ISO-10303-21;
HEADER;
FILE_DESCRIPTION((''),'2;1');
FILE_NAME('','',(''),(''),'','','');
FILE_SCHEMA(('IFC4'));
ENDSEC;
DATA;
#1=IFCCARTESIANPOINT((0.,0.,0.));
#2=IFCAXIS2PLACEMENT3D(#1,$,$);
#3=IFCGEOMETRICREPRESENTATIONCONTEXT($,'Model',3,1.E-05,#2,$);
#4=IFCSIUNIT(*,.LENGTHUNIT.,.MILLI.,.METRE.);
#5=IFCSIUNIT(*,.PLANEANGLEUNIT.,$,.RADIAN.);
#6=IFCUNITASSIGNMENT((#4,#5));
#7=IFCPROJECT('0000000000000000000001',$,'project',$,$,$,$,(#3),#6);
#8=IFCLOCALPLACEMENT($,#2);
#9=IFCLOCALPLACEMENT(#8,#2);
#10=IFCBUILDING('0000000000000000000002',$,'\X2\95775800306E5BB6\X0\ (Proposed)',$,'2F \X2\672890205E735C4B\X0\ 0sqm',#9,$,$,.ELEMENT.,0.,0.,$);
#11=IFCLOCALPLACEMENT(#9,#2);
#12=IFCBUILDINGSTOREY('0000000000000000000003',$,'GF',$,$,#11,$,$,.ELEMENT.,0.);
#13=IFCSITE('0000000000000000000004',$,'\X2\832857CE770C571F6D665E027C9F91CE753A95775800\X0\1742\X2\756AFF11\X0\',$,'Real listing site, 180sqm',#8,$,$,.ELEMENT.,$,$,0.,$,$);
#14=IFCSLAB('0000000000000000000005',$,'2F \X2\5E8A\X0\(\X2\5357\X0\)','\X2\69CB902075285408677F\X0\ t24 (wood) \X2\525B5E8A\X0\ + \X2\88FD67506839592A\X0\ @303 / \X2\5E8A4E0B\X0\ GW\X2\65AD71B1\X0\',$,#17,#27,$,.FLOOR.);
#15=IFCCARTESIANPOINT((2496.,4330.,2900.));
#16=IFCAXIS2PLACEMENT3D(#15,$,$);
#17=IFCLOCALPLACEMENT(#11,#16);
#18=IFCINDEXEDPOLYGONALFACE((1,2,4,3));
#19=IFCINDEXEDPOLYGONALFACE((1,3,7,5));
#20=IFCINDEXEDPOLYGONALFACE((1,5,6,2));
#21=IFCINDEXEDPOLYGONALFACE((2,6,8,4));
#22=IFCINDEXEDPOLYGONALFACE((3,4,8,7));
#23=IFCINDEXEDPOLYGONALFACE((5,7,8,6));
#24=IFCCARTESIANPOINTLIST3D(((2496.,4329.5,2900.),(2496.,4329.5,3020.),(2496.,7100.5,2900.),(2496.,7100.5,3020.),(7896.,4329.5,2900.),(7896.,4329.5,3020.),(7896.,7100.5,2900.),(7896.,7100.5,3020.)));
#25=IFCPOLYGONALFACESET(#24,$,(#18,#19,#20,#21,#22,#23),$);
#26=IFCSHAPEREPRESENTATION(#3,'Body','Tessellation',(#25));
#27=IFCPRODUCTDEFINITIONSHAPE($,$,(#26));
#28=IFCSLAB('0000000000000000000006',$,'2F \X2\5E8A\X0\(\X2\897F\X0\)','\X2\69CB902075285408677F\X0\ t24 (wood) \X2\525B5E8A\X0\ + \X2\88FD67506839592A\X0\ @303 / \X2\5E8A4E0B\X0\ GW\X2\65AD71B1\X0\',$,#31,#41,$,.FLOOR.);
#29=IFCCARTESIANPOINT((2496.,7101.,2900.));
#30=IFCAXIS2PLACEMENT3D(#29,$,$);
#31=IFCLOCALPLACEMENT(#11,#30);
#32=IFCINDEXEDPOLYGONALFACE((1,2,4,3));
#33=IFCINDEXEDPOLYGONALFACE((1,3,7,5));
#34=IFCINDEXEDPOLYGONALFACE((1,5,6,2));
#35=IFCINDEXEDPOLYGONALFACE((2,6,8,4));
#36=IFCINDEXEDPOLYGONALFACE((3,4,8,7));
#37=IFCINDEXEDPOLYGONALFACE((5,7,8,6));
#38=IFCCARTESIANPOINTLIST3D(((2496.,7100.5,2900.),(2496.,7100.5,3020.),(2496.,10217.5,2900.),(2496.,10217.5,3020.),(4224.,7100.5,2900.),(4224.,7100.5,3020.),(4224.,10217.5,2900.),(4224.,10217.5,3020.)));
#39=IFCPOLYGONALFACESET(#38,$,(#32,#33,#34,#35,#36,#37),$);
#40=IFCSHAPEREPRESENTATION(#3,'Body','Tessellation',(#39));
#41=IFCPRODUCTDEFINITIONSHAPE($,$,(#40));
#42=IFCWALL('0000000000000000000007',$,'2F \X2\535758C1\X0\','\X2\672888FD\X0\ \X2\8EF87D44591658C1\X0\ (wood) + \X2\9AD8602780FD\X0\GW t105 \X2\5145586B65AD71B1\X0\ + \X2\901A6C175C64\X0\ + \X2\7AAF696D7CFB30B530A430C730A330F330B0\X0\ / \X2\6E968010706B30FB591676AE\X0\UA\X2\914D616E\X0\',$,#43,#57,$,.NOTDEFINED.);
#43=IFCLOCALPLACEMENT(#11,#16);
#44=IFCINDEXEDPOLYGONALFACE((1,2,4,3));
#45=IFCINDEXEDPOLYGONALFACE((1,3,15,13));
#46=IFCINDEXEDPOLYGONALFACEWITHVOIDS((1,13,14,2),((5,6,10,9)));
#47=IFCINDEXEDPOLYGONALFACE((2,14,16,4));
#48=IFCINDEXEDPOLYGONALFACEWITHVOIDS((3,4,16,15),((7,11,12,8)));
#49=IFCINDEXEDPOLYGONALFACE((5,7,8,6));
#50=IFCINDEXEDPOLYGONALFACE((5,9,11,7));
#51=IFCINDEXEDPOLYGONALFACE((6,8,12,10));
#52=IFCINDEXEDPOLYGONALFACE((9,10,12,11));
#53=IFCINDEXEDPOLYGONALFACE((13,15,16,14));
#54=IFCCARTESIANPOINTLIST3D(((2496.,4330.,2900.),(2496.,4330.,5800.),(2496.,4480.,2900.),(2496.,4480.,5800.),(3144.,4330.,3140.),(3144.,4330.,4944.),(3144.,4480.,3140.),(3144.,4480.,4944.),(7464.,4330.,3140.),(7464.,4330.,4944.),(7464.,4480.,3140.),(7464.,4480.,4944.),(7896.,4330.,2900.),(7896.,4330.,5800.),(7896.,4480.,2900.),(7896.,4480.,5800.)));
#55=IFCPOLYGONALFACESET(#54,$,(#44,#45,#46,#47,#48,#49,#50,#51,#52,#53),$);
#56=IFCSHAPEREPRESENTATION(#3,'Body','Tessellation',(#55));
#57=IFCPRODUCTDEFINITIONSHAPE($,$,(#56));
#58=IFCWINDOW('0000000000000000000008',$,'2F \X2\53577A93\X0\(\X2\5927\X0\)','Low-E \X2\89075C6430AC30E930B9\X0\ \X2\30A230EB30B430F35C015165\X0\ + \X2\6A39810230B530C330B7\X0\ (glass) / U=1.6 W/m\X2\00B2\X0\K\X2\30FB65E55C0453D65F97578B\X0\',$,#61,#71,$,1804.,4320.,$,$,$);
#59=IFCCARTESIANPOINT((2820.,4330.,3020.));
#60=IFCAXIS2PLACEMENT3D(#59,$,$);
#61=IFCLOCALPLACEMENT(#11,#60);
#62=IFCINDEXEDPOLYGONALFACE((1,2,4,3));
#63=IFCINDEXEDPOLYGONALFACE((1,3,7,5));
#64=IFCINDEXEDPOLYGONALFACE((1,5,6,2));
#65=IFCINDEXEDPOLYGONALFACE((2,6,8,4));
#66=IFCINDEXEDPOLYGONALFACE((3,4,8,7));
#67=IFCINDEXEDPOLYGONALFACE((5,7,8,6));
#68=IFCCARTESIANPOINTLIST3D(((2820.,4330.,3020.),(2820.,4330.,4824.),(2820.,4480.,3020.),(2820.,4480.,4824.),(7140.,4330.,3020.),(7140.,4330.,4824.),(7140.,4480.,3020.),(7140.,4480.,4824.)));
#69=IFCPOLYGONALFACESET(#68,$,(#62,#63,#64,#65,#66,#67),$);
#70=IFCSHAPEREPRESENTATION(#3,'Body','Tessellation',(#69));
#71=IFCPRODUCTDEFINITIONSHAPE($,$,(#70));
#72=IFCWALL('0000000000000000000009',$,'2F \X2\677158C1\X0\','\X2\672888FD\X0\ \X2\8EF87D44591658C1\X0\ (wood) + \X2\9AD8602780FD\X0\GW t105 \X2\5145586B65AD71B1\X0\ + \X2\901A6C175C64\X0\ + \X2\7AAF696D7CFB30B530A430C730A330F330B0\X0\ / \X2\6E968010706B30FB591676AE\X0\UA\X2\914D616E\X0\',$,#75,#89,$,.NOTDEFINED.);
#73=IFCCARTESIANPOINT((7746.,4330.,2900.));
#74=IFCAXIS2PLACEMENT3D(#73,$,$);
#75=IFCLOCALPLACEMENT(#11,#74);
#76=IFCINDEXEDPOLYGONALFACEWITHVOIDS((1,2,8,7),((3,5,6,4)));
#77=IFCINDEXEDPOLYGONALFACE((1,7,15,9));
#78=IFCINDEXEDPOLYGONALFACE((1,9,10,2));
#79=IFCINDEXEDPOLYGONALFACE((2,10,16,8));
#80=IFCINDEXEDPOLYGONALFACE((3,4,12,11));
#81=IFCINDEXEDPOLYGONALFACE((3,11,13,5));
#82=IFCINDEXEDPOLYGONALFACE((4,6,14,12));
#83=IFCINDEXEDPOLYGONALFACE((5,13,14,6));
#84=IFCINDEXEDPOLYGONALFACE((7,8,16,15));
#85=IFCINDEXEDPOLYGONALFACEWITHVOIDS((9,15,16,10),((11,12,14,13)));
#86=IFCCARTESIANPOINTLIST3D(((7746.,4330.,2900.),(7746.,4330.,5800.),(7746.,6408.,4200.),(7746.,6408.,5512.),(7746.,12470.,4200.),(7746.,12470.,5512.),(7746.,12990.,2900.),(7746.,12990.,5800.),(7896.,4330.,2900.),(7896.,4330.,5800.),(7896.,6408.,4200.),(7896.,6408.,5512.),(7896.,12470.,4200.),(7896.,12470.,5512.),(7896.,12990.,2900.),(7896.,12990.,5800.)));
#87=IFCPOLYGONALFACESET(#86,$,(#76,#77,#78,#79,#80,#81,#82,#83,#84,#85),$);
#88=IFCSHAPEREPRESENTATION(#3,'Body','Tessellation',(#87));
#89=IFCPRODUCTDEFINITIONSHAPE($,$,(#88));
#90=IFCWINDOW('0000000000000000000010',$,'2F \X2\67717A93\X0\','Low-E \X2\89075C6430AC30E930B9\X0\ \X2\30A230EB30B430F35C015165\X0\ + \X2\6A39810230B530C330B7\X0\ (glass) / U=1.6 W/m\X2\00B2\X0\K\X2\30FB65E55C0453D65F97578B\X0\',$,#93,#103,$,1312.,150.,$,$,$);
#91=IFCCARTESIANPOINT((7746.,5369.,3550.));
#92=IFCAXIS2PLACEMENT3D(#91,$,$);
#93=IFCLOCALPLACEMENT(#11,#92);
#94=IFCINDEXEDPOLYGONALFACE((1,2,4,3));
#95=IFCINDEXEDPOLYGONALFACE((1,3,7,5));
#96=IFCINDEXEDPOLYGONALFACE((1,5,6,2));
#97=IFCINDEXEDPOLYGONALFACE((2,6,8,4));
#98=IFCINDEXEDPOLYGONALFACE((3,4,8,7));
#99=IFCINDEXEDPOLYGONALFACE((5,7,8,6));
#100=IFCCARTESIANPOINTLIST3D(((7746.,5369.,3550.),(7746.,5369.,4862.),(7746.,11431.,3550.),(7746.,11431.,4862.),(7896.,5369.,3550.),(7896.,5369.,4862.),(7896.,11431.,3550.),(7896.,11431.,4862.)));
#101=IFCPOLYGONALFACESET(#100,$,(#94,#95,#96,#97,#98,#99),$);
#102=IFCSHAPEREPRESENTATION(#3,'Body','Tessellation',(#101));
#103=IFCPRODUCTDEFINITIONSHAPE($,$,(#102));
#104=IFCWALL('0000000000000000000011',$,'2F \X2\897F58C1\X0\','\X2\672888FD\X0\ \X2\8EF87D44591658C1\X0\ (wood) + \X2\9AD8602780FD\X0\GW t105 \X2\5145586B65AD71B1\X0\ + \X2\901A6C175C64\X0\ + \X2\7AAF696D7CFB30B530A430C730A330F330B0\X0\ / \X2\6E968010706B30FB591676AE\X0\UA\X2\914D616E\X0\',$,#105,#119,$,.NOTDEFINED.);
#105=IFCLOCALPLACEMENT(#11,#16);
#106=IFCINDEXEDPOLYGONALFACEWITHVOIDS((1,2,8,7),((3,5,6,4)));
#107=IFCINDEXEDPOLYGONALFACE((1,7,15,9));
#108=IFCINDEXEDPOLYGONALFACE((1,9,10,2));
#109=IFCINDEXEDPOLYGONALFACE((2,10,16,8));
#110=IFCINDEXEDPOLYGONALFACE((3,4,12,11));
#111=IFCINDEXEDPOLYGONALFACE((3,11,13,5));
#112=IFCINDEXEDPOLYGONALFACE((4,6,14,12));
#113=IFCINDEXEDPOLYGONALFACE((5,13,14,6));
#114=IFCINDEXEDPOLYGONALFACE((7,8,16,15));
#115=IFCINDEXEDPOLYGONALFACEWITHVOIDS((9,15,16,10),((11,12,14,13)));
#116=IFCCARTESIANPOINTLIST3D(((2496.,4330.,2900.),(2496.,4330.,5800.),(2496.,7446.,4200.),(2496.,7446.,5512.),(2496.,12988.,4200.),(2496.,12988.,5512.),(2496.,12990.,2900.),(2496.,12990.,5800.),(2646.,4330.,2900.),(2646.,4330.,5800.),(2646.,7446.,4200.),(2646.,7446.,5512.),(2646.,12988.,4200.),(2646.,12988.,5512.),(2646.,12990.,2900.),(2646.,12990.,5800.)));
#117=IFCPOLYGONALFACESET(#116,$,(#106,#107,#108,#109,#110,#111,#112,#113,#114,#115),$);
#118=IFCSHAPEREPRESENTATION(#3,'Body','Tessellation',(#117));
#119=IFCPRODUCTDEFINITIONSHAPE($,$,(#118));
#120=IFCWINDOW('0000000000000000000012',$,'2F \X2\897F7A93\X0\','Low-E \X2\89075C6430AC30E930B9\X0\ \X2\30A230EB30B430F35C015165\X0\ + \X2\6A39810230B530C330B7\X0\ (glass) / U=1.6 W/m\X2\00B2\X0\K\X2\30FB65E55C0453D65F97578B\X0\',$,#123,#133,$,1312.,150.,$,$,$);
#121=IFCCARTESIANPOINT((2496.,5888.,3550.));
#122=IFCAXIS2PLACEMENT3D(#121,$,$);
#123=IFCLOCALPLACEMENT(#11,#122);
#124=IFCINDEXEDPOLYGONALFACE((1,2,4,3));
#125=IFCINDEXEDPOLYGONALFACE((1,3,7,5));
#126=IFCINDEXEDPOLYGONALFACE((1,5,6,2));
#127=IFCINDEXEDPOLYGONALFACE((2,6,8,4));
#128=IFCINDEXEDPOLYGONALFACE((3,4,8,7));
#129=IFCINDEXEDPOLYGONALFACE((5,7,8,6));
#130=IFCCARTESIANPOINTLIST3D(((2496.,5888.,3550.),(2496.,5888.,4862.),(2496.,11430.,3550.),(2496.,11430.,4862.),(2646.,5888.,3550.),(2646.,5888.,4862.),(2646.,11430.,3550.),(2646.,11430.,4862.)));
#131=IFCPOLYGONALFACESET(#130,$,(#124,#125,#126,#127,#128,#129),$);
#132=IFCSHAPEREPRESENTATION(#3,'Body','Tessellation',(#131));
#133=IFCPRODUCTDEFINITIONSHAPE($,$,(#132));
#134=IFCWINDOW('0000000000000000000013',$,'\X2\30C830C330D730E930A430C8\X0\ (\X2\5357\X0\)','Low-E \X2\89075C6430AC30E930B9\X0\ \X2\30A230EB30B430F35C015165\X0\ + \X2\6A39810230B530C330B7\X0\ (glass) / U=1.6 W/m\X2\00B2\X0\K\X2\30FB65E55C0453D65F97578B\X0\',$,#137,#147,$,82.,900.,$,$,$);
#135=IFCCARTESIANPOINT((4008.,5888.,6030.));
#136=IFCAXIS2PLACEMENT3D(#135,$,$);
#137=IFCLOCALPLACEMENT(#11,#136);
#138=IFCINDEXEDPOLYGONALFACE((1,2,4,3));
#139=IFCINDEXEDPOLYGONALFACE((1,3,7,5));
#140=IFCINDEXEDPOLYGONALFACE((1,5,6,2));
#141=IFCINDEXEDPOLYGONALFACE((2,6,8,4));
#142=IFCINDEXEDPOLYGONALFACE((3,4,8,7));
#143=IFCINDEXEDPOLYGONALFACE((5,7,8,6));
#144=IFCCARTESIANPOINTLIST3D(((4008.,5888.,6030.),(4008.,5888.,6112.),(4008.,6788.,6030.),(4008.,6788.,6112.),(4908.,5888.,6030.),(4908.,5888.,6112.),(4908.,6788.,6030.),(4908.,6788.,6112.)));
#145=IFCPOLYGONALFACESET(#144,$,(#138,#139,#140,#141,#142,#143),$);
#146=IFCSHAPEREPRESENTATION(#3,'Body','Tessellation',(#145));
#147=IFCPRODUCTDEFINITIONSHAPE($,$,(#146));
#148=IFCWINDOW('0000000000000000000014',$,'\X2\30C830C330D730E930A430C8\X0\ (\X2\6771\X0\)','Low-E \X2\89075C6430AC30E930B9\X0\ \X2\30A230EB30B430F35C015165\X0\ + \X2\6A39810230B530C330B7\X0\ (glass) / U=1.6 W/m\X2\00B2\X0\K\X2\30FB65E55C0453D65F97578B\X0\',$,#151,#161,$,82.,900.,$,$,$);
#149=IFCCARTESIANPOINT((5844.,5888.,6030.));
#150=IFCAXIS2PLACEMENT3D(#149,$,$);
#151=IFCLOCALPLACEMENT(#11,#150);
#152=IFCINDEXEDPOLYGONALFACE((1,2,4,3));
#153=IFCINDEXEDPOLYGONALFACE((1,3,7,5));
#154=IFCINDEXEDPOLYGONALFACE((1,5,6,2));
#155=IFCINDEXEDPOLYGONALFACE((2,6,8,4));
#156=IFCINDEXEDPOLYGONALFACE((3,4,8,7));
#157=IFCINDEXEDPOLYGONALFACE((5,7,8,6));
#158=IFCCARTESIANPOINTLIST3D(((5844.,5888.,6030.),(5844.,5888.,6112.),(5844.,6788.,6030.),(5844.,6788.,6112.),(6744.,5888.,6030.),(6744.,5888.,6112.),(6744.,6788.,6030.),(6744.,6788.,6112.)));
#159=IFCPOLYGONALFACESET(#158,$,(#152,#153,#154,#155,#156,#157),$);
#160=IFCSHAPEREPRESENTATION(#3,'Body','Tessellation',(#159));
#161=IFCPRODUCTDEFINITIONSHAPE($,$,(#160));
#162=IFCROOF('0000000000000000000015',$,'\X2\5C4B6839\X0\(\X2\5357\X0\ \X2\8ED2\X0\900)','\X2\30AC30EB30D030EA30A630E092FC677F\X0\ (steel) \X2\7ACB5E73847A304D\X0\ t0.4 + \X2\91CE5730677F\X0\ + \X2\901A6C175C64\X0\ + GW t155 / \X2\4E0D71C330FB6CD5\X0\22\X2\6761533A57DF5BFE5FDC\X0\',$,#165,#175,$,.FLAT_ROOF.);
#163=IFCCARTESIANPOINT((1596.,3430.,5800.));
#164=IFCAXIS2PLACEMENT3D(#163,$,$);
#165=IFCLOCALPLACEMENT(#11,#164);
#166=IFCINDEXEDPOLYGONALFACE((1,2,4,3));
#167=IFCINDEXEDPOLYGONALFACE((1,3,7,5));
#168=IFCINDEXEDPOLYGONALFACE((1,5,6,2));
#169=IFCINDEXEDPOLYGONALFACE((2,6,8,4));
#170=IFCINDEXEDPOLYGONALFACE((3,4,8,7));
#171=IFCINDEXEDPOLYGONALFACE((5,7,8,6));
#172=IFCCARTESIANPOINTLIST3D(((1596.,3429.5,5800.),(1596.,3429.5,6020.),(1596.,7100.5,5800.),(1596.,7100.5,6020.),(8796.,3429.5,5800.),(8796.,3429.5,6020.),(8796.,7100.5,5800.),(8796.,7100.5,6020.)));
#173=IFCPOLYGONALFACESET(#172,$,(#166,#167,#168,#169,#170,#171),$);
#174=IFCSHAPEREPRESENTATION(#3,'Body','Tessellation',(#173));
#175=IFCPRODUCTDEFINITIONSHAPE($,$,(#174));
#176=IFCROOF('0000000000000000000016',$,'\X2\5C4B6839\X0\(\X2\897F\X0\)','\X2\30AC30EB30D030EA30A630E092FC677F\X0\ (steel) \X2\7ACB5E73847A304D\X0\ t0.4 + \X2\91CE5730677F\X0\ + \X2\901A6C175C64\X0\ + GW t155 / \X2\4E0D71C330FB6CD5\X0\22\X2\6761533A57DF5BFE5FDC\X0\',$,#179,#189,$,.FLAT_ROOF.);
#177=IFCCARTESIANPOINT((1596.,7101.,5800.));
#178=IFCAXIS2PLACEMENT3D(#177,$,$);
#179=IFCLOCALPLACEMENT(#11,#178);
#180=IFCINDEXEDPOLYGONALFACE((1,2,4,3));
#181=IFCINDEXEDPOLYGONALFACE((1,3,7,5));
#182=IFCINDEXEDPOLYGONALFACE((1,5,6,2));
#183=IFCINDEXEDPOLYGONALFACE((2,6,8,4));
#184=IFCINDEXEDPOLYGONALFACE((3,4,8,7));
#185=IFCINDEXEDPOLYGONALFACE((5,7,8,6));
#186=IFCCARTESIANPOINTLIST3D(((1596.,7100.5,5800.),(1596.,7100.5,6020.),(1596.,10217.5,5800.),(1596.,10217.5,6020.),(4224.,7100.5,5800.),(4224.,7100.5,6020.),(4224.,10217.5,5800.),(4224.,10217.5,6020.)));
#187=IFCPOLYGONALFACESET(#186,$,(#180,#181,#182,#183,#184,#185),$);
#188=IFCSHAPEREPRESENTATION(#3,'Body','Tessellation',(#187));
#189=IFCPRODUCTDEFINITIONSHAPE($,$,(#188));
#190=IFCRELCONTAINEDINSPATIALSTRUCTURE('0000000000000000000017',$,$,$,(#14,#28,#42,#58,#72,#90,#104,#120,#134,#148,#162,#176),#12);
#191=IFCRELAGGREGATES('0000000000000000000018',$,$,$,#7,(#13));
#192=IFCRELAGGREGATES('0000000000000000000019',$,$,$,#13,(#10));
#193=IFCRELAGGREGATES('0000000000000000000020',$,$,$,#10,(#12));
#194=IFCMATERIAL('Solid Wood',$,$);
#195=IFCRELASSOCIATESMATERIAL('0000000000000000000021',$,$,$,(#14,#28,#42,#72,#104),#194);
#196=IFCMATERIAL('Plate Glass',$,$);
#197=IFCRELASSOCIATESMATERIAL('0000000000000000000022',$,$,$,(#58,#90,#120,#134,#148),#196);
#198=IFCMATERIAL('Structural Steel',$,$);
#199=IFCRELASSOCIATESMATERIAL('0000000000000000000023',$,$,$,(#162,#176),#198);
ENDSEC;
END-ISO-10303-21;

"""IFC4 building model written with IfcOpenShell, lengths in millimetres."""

from ifc_helpers import new_model, si_unit, frame, frame_2d, origin, place, context, project, spatial, rectangle, extrude, material, element, fill, save


model = new_model("IFC4")

# Units and contexts
model_context = context("Model", 3, precision=1e-05, world=origin())
ifc_project = project(units=[si_unit("LENGTHUNIT", "METRE", prefix="MILLI"), si_unit("PLANEANGLEUNIT", "RADIAN")], contexts=[model_context])

# Site, building, storey
site_placement = place(None, origin())
site = spatial("IfcSite", under=ifc_project, at=site_placement, Name="茨城県土浦市粟野町長堀1742番１", ObjectType="Real listing site, 180sqm", CompositionType="ELEMENT", RefElevation=0.0)
building_placement = place(site_placement, origin())
building = spatial("IfcBuilding", under=site, at=building_placement, Name="長堀の家 (Proposed)", ObjectType="2F 木造平屋 0sqm", CompositionType="ELEMENT", ElevationOfRefHeight=0.0, ElevationOfTerrain=0.0)
storey_placement = place(building_placement, origin())
storey = spatial("IfcBuildingStorey", under=building, at=storey_placement, Name="GF", CompositionType="ELEMENT", Elevation=0.0)

# Slabs
ifc_material_1 = material(Name="Solid Wood")
slab_1_placement = place(storey_placement, frame((2496.0, 4330.0, 2900.0)))
element("IfcSlab", 1, at=slab_1_placement, inside=storey, material=ifc_material_1, Name="2F 床(南)", Description="構造用合板 t24 (wood) 剛床 + 製材根太 @303 / 床下 GW断熱", PredefinedType="FLOOR", context=model_context, shape_type="SweptSolid", body=[
    extrude(rectangle(XDim=5400.0, YDim=2771.0, at=frame_2d((2700.0, 1385.0))), frame((2496.0, 4330.0, 2900.0)), (0.0, 0.0, 1.0), 120.0),
])
slab_2_placement = place(storey_placement, frame((2496.0, 7101.0, 2900.0)))
element("IfcSlab", 2, at=slab_2_placement, inside=storey, material=ifc_material_1, Name="2F 床(西)", Description="構造用合板 t24 (wood) 剛床 + 製材根太 @303 / 床下 GW断熱", PredefinedType="FLOOR", context=model_context, shape_type="SweptSolid", body=[
    extrude(rectangle(XDim=1728.0, YDim=3117.0, at=frame_2d((864.0, 1558.0))), frame((2496.0, 7101.0, 2900.0)), (0.0, 0.0, 1.0), 120.0),
])

# Walls, openings, windows
wall_1_placement = place(storey_placement, frame((2496.0, 4330.0, 2900.0)))
wall_1 = element("IfcWall", 3, at=wall_1_placement, inside=storey, material=ifc_material_1, Name="2F 南壁", Description="木製 軸組外壁 (wood) + 高性能GW t105 充填断熱 + 通気層 + 窯業系サイディング / 準耐火・外皮UA配慮", PredefinedType="NOTDEFINED", context=model_context, shape_type="SweptSolid", body=[
    extrude(rectangle(XDim=5400.0, YDim=150.0, at=frame_2d((2700.0, 75.0))), frame((2496.0, 4330.0, 2900.0)), (0.0, 0.0, 1.0), 2900.0),
])
opening_1_placement = place(storey_placement, frame((2820.0, 4330.0, 3020.0)))
opening_1 = element("IfcOpeningElement", 4, at=opening_1_placement, cuts=wall_1, PredefinedType="NOTDEFINED", context=model_context, shape_type="SweptSolid", body=[
    extrude(rectangle(XDim=4320.0, YDim=150.0, at=frame_2d((2160.0, 75.0))), frame((2820.0, 4330.0, 3020.0)), (0.0, 0.0, 1.0), 1804.0),
])
ifc_material_2 = material(Name="Plate Glass")
window_1_placement = place(storey_placement, frame((2820.0, 4330.0, 3020.0)))
window_1 = element("IfcWindow", 5, at=window_1_placement, inside=storey, material=ifc_material_2, Name="2F 南窓(大)", Description="Low-E 複層ガラス アルゴン封入 + 樹脂サッシ (glass) / U=1.6 W/m²K・日射取得型", OverallHeight=1804.0, OverallWidth=4320.0, context=model_context, shape_type="SweptSolid", body=[
    extrude(rectangle(XDim=4320.0, YDim=150.0, at=frame_2d((2160.0, 75.0))), frame((2820.0, 4330.0, 3020.0)), (0.0, 0.0, 1.0), 1804.0),
])
fill(opening_1, window_1)
wall_2_placement = place(storey_placement, frame((7746.0, 4330.0, 2900.0)))
wall_2 = element("IfcWall", 6, at=wall_2_placement, inside=storey, material=ifc_material_1, Name="2F 東壁", Description="木製 軸組外壁 (wood) + 高性能GW t105 充填断熱 + 通気層 + 窯業系サイディング / 準耐火・外皮UA配慮", PredefinedType="NOTDEFINED", context=model_context, shape_type="SweptSolid", body=[
    extrude(rectangle(XDim=150.0, YDim=8660.0, at=frame_2d((75.0, 4330.0))), frame((7746.0, 4330.0, 2900.0)), (0.0, 0.0, 1.0), 2900.0),
])
opening_2_placement = place(storey_placement, frame((7746.0, 5369.0, 3550.0)))
opening_2 = element("IfcOpeningElement", 7, at=opening_2_placement, cuts=wall_2, PredefinedType="NOTDEFINED", context=model_context, shape_type="SweptSolid", body=[
    extrude(rectangle(XDim=150.0, YDim=6062.0, at=frame_2d((75.0, 3031.0))), frame((7746.0, 5369.0, 3550.0)), (0.0, 0.0, 1.0), 1312.0),
])
window_2_placement = place(storey_placement, frame((7746.0, 5369.0, 3550.0)))
window_2 = element("IfcWindow", 8, at=window_2_placement, inside=storey, material=ifc_material_2, Name="2F 東窓", Description="Low-E 複層ガラス アルゴン封入 + 樹脂サッシ (glass) / U=1.6 W/m²K・日射取得型", OverallHeight=1312.0, OverallWidth=150.0, context=model_context, shape_type="SweptSolid", body=[
    extrude(rectangle(XDim=150.0, YDim=6062.0, at=frame_2d((75.0, 3031.0))), frame((7746.0, 5369.0, 3550.0)), (0.0, 0.0, 1.0), 1312.0),
])
fill(opening_2, window_2)
wall_3_placement = place(storey_placement, frame((2496.0, 4330.0, 2900.0)))
wall_3 = element("IfcWall", 9, at=wall_3_placement, inside=storey, material=ifc_material_1, Name="2F 西壁", Description="木製 軸組外壁 (wood) + 高性能GW t105 充填断熱 + 通気層 + 窯業系サイディング / 準耐火・外皮UA配慮", PredefinedType="NOTDEFINED", context=model_context, shape_type="SweptSolid", body=[
    extrude(rectangle(XDim=150.0, YDim=8660.0, at=frame_2d((75.0, 4330.0))), frame((2496.0, 4330.0, 2900.0)), (0.0, 0.0, 1.0), 2900.0),
])
opening_3_placement = place(storey_placement, frame((2496.0, 5888.0, 3550.0)))
opening_3 = element("IfcOpeningElement", 10, at=opening_3_placement, cuts=wall_3, PredefinedType="NOTDEFINED", context=model_context, shape_type="SweptSolid", body=[
    extrude(rectangle(XDim=150.0, YDim=5542.0, at=frame_2d((75.0, 2771.0))), frame((2496.0, 5888.0, 3550.0)), (0.0, 0.0, 1.0), 1312.0),
])
window_3_placement = place(storey_placement, frame((2496.0, 5888.0, 3550.0)))
window_3 = element("IfcWindow", 11, at=window_3_placement, inside=storey, material=ifc_material_2, Name="2F 西窓", Description="Low-E 複層ガラス アルゴン封入 + 樹脂サッシ (glass) / U=1.6 W/m²K・日射取得型", OverallHeight=1312.0, OverallWidth=150.0, context=model_context, shape_type="SweptSolid", body=[
    extrude(rectangle(XDim=150.0, YDim=5542.0, at=frame_2d((75.0, 2771.0))), frame((2496.0, 5888.0, 3550.0)), (0.0, 0.0, 1.0), 1312.0),
])
fill(opening_3, window_3)

# Windows
window_4_placement = place(storey_placement, frame((4008.0, 5888.0, 6030.0)))
element("IfcWindow", 12, at=window_4_placement, inside=storey, material=ifc_material_2, Name="トップライト (南)", Description="Low-E 複層ガラス アルゴン封入 + 樹脂サッシ (glass) / U=1.6 W/m²K・日射取得型", OverallHeight=82.0, OverallWidth=900.0, context=model_context, shape_type="SweptSolid", body=[
    extrude(rectangle(XDim=900.0, YDim=900.0, at=frame_2d((450.0, 450.0))), frame((4008.0, 5888.0, 6030.0)), (0.0, 0.0, 1.0), 82.0),
])
window_5_placement = place(storey_placement, frame((5844.0, 5888.0, 6030.0)))
element("IfcWindow", 13, at=window_5_placement, inside=storey, material=ifc_material_2, Name="トップライト (東)", Description="Low-E 複層ガラス アルゴン封入 + 樹脂サッシ (glass) / U=1.6 W/m²K・日射取得型", OverallHeight=82.0, OverallWidth=900.0, context=model_context, shape_type="SweptSolid", body=[
    extrude(rectangle(XDim=900.0, YDim=900.0, at=frame_2d((450.0, 450.0))), frame((5844.0, 5888.0, 6030.0)), (0.0, 0.0, 1.0), 82.0),
])

# Roofs
ifc_material_3 = material(Name="Structural Steel")
roof_1_placement = place(storey_placement, frame((1596.0, 3430.0, 5800.0)))
element("IfcRoof", 14, at=roof_1_placement, inside=storey, material=ifc_material_3, Name="屋根(南 軒900)", Description="ガルバリウム鋼板 (steel) 立平葺き t0.4 + 野地板 + 通気層 + GW t155 / 不燃・法22条区域対応", PredefinedType="FLAT_ROOF", context=model_context, shape_type="SweptSolid", body=[
    extrude(rectangle(XDim=7200.0, YDim=3671.0, at=frame_2d((3600.0, 1835.0))), frame((1596.0, 3430.0, 5800.0)), (0.0, 0.0, 1.0), 220.0),
])
roof_2_placement = place(storey_placement, frame((1596.0, 7101.0, 5800.0)))
element("IfcRoof", 15, at=roof_2_placement, inside=storey, material=ifc_material_3, Name="屋根(西)", Description="ガルバリウム鋼板 (steel) 立平葺き t0.4 + 野地板 + 通気層 + GW t155 / 不燃・法22条区域対応", PredefinedType="FLAT_ROOF", context=model_context, shape_type="SweptSolid", body=[
    extrude(rectangle(XDim=2628.0, YDim=3117.0, at=frame_2d((1314.0, 1558.0))), frame((1596.0, 7101.0, 5800.0)), (0.0, 0.0, 1.0), 220.0),
])

save(model, "model.ifc")
